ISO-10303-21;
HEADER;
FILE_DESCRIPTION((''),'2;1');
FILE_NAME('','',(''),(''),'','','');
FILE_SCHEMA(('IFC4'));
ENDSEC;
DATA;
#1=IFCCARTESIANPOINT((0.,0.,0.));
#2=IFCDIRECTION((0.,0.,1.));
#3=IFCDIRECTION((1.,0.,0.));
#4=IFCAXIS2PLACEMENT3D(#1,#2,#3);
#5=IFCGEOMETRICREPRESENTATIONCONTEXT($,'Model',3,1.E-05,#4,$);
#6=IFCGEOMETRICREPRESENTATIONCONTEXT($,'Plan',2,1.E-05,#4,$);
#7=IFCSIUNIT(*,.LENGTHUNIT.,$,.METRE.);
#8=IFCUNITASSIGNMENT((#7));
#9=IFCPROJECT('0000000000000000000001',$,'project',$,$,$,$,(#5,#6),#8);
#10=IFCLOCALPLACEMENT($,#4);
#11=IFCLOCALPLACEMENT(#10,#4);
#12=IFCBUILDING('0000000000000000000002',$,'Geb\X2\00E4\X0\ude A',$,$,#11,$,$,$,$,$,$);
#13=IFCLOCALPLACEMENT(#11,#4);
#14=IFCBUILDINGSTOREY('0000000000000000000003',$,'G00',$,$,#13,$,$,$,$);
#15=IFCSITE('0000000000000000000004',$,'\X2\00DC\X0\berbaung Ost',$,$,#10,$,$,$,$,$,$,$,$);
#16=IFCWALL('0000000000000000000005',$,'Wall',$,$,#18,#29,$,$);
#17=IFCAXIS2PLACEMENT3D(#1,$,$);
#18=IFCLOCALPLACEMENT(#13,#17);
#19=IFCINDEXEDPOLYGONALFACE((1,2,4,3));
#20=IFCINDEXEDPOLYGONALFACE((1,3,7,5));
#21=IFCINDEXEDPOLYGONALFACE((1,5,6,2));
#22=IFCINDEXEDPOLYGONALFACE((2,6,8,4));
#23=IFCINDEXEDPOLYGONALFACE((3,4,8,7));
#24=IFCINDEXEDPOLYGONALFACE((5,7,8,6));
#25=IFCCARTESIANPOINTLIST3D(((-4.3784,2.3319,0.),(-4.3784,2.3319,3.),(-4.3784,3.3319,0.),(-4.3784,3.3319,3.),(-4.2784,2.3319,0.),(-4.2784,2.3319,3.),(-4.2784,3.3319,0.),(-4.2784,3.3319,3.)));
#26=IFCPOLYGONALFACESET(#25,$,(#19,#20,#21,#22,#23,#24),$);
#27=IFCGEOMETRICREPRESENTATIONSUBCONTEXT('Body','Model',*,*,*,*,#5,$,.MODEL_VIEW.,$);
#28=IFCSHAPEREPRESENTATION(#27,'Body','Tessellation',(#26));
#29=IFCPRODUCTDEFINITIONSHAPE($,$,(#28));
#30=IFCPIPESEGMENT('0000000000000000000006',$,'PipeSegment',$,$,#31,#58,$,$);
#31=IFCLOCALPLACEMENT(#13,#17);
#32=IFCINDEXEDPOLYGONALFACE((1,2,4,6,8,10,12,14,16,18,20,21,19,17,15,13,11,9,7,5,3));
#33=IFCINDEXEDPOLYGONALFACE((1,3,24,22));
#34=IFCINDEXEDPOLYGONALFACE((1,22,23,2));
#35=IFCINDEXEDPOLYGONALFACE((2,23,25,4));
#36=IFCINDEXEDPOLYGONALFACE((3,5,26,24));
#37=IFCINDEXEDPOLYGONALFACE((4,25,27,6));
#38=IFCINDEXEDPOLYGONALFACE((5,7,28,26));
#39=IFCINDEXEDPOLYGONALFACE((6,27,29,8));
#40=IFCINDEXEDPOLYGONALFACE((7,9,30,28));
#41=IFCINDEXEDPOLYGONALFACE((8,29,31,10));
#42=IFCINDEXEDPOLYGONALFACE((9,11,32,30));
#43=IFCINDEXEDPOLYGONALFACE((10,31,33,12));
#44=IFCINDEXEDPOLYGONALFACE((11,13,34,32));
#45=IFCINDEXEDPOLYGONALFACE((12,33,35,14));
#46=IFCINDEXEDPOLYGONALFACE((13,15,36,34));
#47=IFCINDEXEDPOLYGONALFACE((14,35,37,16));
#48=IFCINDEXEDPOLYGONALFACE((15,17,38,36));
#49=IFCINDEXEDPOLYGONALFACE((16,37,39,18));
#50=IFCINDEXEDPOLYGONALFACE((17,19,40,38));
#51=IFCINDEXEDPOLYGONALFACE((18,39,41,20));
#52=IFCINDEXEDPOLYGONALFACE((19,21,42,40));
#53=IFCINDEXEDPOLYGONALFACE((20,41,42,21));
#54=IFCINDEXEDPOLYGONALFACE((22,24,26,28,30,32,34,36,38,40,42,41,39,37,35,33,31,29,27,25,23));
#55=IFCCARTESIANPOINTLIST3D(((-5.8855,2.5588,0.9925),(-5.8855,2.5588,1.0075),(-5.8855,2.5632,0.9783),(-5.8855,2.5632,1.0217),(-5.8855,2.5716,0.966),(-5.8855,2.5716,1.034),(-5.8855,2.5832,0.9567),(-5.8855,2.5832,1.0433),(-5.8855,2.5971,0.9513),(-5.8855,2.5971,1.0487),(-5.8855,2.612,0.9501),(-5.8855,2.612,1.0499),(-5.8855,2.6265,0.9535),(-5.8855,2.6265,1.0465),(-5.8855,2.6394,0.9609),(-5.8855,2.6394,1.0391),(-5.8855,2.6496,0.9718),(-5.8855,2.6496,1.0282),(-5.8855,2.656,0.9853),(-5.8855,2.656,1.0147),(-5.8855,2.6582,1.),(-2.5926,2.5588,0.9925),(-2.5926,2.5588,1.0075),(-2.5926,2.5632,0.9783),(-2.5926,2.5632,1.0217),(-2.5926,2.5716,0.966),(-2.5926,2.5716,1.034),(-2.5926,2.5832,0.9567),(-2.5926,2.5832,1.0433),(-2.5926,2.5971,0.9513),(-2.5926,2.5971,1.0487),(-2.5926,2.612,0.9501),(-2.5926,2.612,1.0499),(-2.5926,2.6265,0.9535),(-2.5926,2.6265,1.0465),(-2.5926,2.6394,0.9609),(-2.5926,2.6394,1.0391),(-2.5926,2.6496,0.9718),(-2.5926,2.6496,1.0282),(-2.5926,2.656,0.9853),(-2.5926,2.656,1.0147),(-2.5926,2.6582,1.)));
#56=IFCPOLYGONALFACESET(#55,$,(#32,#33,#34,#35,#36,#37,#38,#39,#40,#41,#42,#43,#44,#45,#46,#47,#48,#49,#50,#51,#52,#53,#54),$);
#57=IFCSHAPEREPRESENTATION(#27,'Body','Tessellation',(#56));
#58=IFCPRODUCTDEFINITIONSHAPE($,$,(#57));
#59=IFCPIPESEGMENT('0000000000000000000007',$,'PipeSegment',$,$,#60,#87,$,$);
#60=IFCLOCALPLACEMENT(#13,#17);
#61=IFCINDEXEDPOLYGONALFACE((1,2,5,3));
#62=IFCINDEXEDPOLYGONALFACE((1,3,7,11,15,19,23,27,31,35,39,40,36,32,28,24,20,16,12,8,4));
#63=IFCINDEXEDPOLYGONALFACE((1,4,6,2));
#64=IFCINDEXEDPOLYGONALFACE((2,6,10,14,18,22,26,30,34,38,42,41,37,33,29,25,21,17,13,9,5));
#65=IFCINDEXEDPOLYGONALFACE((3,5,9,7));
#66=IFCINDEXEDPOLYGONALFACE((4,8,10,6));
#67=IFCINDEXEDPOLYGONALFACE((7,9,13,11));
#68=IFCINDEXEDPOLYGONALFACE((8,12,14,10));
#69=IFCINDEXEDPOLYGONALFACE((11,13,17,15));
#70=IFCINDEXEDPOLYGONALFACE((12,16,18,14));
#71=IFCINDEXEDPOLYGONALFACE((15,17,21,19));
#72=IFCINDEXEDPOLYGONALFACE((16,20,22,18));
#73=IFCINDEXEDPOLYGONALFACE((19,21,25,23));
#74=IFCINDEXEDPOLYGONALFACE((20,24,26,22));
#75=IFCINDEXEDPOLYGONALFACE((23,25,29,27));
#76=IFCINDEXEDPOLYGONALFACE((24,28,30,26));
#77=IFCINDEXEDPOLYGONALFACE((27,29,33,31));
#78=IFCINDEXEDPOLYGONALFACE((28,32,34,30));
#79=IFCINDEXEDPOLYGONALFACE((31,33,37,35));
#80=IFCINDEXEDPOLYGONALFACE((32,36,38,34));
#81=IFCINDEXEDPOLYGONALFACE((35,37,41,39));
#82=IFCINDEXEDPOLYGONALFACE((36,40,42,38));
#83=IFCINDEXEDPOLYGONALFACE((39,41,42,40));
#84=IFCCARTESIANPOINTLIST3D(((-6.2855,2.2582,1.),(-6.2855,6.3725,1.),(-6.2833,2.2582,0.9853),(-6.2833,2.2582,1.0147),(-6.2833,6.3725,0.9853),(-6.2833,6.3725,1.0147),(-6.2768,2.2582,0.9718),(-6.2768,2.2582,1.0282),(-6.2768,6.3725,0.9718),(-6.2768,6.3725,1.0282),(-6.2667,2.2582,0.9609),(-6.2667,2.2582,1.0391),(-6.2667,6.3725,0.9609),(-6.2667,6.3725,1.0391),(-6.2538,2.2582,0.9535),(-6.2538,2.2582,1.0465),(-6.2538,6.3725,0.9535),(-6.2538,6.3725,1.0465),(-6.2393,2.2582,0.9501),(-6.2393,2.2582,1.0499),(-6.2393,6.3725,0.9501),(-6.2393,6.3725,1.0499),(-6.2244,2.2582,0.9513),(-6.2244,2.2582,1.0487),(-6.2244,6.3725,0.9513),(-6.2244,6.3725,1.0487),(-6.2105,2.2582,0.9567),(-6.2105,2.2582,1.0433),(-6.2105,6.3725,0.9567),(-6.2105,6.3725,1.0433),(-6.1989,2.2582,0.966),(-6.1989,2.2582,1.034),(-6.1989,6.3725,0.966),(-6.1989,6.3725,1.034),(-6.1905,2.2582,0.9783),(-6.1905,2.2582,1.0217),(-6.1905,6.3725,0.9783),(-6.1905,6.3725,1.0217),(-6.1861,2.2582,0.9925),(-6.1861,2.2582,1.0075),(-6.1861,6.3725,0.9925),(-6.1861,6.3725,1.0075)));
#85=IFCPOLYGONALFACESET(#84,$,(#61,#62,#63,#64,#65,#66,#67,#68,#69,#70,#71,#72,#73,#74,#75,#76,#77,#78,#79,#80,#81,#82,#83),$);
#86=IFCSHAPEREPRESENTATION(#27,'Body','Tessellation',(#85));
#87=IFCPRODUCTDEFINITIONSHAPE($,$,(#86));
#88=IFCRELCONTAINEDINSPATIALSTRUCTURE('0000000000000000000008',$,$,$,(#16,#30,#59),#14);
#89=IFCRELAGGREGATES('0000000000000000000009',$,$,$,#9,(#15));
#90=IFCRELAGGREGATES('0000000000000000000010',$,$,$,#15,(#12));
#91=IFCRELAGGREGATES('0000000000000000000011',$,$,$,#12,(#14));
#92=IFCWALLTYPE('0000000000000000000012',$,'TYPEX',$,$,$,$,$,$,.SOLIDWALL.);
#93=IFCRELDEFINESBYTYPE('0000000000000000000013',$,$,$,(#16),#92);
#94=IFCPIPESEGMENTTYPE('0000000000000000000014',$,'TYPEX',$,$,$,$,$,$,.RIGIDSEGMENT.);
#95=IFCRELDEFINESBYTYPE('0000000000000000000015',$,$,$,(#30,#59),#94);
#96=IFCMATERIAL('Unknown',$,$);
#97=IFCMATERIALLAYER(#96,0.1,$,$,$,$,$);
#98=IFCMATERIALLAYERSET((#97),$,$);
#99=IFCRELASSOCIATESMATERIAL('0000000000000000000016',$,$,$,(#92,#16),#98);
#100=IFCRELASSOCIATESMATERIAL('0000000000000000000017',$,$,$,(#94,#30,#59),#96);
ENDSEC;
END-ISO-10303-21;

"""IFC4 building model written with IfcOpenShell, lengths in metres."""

from ifc_helpers import new_model, si_unit, frame, origin_with_axes, place, context, subcontext, project, spatial, indexed_curve, circle, outline, extrude, material, layer, layer_set, layer_usage, material_profile, profile_set, profile_usage, type_object, element, save


model = new_model("IFC4")

# Units and contexts
model_context = context("Model", 3, precision=1e-05, world=origin_with_axes())
plan_context = context("Plan", 2, precision=1e-05, world=origin_with_axes())
body_context = subcontext(model_context, "Body", "Model", "MODEL_VIEW")
ifc_project = project(units=[si_unit("LENGTHUNIT", "METRE")], contexts=[model_context, plan_context])

# Site, building, storey
site_placement = place(None, origin_with_axes())
site = spatial("IfcSite", under=ifc_project, at=site_placement, Name="Überbaung Ost")
building_placement = place(site_placement, origin_with_axes())
building = spatial("IfcBuilding", under=site, at=building_placement, Name="Gebäude A")
storey_placement = place(building_placement, origin_with_axes())
storey = spatial("IfcBuildingStorey", under=building, at=storey_placement, Name="G00")

# Wall
ifc_material = material(Name="Unknown")
ifc_layer = layer(ifc_material, 0.1)
ifc_layer_set = layer_set([ifc_layer])
ifc_layer_usage = layer_usage(ifc_layer_set, "AXIS2", "POSITIVE", 0.0)
wall_type = type_object("IfcWallType", Name="TYPEX", PredefinedType="SOLIDWALL", material=ifc_layer_set)
wall_placement = place(storey_placement, frame((-4.2784, 2.3319, 0.0), z_axis=(0.0, 0.0, 1.0), x_axis=(0.0, 1.0, 0.0)))
element("IfcWall", 1, at=wall_placement, inside=storey, type_object=wall_type, material=ifc_layer_usage, Name="Wall", context=body_context, shape_type="SweptSolid", body=[
    extrude(outline(indexed_curve([(0.0, 0.0), (0.0, 0.1), (1.0, 0.1), (1.0, 0.0), (0.0, 0.0)], self_intersect=False)), origin_with_axes(), (0.0, 0.0, 1.0), 3.0),
])

# Pipe segments
ifc_material_profile = material_profile(ifc_material, circle(Radius=0.05))
ifc_profile_set = profile_set([ifc_material_profile])
ifc_profile_usage_1 = profile_usage(ifc_profile_set, cardinal=5)
pipe_segment_type = type_object("IfcPipeSegmentType", Name="TYPEX", PredefinedType="RIGIDSEGMENT", material=ifc_profile_set)
pipe_segment_1_placement = place(storey_placement, frame((-5.8855, 2.6082, 1.0), z_axis=(1.0, 0.0, 0.0), x_axis=(0.0, 1.0, 0.0)))
element("IfcPipeSegment", 2, at=pipe_segment_1_placement, inside=storey, type_object=pipe_segment_type, material=ifc_profile_usage_1, Name="PipeSegment", context=body_context, shape_type="SweptSolid", body=[
    extrude(circle(Radius=0.05), origin_with_axes(), (0.0, 0.0, 1.0), 3.293),
])
ifc_profile_usage_2 = profile_usage(ifc_profile_set, cardinal=5)
pipe_segment_2_placement = place(storey_placement, frame((-6.2355, 2.2582, 1.0), z_axis=(0.0, 1.0, 0.0), x_axis=(-1.0, 0.0, 0.0)))
element("IfcPipeSegment", 3, at=pipe_segment_2_placement, inside=storey, type_object=pipe_segment_type, material=ifc_profile_usage_2, Name="PipeSegment", context=body_context, shape_type="SweptSolid", body=[
    extrude(circle(Radius=0.05), origin_with_axes(), (0.0, 0.0, 1.0), 4.1143),
])

save(model, "model.ifc")
